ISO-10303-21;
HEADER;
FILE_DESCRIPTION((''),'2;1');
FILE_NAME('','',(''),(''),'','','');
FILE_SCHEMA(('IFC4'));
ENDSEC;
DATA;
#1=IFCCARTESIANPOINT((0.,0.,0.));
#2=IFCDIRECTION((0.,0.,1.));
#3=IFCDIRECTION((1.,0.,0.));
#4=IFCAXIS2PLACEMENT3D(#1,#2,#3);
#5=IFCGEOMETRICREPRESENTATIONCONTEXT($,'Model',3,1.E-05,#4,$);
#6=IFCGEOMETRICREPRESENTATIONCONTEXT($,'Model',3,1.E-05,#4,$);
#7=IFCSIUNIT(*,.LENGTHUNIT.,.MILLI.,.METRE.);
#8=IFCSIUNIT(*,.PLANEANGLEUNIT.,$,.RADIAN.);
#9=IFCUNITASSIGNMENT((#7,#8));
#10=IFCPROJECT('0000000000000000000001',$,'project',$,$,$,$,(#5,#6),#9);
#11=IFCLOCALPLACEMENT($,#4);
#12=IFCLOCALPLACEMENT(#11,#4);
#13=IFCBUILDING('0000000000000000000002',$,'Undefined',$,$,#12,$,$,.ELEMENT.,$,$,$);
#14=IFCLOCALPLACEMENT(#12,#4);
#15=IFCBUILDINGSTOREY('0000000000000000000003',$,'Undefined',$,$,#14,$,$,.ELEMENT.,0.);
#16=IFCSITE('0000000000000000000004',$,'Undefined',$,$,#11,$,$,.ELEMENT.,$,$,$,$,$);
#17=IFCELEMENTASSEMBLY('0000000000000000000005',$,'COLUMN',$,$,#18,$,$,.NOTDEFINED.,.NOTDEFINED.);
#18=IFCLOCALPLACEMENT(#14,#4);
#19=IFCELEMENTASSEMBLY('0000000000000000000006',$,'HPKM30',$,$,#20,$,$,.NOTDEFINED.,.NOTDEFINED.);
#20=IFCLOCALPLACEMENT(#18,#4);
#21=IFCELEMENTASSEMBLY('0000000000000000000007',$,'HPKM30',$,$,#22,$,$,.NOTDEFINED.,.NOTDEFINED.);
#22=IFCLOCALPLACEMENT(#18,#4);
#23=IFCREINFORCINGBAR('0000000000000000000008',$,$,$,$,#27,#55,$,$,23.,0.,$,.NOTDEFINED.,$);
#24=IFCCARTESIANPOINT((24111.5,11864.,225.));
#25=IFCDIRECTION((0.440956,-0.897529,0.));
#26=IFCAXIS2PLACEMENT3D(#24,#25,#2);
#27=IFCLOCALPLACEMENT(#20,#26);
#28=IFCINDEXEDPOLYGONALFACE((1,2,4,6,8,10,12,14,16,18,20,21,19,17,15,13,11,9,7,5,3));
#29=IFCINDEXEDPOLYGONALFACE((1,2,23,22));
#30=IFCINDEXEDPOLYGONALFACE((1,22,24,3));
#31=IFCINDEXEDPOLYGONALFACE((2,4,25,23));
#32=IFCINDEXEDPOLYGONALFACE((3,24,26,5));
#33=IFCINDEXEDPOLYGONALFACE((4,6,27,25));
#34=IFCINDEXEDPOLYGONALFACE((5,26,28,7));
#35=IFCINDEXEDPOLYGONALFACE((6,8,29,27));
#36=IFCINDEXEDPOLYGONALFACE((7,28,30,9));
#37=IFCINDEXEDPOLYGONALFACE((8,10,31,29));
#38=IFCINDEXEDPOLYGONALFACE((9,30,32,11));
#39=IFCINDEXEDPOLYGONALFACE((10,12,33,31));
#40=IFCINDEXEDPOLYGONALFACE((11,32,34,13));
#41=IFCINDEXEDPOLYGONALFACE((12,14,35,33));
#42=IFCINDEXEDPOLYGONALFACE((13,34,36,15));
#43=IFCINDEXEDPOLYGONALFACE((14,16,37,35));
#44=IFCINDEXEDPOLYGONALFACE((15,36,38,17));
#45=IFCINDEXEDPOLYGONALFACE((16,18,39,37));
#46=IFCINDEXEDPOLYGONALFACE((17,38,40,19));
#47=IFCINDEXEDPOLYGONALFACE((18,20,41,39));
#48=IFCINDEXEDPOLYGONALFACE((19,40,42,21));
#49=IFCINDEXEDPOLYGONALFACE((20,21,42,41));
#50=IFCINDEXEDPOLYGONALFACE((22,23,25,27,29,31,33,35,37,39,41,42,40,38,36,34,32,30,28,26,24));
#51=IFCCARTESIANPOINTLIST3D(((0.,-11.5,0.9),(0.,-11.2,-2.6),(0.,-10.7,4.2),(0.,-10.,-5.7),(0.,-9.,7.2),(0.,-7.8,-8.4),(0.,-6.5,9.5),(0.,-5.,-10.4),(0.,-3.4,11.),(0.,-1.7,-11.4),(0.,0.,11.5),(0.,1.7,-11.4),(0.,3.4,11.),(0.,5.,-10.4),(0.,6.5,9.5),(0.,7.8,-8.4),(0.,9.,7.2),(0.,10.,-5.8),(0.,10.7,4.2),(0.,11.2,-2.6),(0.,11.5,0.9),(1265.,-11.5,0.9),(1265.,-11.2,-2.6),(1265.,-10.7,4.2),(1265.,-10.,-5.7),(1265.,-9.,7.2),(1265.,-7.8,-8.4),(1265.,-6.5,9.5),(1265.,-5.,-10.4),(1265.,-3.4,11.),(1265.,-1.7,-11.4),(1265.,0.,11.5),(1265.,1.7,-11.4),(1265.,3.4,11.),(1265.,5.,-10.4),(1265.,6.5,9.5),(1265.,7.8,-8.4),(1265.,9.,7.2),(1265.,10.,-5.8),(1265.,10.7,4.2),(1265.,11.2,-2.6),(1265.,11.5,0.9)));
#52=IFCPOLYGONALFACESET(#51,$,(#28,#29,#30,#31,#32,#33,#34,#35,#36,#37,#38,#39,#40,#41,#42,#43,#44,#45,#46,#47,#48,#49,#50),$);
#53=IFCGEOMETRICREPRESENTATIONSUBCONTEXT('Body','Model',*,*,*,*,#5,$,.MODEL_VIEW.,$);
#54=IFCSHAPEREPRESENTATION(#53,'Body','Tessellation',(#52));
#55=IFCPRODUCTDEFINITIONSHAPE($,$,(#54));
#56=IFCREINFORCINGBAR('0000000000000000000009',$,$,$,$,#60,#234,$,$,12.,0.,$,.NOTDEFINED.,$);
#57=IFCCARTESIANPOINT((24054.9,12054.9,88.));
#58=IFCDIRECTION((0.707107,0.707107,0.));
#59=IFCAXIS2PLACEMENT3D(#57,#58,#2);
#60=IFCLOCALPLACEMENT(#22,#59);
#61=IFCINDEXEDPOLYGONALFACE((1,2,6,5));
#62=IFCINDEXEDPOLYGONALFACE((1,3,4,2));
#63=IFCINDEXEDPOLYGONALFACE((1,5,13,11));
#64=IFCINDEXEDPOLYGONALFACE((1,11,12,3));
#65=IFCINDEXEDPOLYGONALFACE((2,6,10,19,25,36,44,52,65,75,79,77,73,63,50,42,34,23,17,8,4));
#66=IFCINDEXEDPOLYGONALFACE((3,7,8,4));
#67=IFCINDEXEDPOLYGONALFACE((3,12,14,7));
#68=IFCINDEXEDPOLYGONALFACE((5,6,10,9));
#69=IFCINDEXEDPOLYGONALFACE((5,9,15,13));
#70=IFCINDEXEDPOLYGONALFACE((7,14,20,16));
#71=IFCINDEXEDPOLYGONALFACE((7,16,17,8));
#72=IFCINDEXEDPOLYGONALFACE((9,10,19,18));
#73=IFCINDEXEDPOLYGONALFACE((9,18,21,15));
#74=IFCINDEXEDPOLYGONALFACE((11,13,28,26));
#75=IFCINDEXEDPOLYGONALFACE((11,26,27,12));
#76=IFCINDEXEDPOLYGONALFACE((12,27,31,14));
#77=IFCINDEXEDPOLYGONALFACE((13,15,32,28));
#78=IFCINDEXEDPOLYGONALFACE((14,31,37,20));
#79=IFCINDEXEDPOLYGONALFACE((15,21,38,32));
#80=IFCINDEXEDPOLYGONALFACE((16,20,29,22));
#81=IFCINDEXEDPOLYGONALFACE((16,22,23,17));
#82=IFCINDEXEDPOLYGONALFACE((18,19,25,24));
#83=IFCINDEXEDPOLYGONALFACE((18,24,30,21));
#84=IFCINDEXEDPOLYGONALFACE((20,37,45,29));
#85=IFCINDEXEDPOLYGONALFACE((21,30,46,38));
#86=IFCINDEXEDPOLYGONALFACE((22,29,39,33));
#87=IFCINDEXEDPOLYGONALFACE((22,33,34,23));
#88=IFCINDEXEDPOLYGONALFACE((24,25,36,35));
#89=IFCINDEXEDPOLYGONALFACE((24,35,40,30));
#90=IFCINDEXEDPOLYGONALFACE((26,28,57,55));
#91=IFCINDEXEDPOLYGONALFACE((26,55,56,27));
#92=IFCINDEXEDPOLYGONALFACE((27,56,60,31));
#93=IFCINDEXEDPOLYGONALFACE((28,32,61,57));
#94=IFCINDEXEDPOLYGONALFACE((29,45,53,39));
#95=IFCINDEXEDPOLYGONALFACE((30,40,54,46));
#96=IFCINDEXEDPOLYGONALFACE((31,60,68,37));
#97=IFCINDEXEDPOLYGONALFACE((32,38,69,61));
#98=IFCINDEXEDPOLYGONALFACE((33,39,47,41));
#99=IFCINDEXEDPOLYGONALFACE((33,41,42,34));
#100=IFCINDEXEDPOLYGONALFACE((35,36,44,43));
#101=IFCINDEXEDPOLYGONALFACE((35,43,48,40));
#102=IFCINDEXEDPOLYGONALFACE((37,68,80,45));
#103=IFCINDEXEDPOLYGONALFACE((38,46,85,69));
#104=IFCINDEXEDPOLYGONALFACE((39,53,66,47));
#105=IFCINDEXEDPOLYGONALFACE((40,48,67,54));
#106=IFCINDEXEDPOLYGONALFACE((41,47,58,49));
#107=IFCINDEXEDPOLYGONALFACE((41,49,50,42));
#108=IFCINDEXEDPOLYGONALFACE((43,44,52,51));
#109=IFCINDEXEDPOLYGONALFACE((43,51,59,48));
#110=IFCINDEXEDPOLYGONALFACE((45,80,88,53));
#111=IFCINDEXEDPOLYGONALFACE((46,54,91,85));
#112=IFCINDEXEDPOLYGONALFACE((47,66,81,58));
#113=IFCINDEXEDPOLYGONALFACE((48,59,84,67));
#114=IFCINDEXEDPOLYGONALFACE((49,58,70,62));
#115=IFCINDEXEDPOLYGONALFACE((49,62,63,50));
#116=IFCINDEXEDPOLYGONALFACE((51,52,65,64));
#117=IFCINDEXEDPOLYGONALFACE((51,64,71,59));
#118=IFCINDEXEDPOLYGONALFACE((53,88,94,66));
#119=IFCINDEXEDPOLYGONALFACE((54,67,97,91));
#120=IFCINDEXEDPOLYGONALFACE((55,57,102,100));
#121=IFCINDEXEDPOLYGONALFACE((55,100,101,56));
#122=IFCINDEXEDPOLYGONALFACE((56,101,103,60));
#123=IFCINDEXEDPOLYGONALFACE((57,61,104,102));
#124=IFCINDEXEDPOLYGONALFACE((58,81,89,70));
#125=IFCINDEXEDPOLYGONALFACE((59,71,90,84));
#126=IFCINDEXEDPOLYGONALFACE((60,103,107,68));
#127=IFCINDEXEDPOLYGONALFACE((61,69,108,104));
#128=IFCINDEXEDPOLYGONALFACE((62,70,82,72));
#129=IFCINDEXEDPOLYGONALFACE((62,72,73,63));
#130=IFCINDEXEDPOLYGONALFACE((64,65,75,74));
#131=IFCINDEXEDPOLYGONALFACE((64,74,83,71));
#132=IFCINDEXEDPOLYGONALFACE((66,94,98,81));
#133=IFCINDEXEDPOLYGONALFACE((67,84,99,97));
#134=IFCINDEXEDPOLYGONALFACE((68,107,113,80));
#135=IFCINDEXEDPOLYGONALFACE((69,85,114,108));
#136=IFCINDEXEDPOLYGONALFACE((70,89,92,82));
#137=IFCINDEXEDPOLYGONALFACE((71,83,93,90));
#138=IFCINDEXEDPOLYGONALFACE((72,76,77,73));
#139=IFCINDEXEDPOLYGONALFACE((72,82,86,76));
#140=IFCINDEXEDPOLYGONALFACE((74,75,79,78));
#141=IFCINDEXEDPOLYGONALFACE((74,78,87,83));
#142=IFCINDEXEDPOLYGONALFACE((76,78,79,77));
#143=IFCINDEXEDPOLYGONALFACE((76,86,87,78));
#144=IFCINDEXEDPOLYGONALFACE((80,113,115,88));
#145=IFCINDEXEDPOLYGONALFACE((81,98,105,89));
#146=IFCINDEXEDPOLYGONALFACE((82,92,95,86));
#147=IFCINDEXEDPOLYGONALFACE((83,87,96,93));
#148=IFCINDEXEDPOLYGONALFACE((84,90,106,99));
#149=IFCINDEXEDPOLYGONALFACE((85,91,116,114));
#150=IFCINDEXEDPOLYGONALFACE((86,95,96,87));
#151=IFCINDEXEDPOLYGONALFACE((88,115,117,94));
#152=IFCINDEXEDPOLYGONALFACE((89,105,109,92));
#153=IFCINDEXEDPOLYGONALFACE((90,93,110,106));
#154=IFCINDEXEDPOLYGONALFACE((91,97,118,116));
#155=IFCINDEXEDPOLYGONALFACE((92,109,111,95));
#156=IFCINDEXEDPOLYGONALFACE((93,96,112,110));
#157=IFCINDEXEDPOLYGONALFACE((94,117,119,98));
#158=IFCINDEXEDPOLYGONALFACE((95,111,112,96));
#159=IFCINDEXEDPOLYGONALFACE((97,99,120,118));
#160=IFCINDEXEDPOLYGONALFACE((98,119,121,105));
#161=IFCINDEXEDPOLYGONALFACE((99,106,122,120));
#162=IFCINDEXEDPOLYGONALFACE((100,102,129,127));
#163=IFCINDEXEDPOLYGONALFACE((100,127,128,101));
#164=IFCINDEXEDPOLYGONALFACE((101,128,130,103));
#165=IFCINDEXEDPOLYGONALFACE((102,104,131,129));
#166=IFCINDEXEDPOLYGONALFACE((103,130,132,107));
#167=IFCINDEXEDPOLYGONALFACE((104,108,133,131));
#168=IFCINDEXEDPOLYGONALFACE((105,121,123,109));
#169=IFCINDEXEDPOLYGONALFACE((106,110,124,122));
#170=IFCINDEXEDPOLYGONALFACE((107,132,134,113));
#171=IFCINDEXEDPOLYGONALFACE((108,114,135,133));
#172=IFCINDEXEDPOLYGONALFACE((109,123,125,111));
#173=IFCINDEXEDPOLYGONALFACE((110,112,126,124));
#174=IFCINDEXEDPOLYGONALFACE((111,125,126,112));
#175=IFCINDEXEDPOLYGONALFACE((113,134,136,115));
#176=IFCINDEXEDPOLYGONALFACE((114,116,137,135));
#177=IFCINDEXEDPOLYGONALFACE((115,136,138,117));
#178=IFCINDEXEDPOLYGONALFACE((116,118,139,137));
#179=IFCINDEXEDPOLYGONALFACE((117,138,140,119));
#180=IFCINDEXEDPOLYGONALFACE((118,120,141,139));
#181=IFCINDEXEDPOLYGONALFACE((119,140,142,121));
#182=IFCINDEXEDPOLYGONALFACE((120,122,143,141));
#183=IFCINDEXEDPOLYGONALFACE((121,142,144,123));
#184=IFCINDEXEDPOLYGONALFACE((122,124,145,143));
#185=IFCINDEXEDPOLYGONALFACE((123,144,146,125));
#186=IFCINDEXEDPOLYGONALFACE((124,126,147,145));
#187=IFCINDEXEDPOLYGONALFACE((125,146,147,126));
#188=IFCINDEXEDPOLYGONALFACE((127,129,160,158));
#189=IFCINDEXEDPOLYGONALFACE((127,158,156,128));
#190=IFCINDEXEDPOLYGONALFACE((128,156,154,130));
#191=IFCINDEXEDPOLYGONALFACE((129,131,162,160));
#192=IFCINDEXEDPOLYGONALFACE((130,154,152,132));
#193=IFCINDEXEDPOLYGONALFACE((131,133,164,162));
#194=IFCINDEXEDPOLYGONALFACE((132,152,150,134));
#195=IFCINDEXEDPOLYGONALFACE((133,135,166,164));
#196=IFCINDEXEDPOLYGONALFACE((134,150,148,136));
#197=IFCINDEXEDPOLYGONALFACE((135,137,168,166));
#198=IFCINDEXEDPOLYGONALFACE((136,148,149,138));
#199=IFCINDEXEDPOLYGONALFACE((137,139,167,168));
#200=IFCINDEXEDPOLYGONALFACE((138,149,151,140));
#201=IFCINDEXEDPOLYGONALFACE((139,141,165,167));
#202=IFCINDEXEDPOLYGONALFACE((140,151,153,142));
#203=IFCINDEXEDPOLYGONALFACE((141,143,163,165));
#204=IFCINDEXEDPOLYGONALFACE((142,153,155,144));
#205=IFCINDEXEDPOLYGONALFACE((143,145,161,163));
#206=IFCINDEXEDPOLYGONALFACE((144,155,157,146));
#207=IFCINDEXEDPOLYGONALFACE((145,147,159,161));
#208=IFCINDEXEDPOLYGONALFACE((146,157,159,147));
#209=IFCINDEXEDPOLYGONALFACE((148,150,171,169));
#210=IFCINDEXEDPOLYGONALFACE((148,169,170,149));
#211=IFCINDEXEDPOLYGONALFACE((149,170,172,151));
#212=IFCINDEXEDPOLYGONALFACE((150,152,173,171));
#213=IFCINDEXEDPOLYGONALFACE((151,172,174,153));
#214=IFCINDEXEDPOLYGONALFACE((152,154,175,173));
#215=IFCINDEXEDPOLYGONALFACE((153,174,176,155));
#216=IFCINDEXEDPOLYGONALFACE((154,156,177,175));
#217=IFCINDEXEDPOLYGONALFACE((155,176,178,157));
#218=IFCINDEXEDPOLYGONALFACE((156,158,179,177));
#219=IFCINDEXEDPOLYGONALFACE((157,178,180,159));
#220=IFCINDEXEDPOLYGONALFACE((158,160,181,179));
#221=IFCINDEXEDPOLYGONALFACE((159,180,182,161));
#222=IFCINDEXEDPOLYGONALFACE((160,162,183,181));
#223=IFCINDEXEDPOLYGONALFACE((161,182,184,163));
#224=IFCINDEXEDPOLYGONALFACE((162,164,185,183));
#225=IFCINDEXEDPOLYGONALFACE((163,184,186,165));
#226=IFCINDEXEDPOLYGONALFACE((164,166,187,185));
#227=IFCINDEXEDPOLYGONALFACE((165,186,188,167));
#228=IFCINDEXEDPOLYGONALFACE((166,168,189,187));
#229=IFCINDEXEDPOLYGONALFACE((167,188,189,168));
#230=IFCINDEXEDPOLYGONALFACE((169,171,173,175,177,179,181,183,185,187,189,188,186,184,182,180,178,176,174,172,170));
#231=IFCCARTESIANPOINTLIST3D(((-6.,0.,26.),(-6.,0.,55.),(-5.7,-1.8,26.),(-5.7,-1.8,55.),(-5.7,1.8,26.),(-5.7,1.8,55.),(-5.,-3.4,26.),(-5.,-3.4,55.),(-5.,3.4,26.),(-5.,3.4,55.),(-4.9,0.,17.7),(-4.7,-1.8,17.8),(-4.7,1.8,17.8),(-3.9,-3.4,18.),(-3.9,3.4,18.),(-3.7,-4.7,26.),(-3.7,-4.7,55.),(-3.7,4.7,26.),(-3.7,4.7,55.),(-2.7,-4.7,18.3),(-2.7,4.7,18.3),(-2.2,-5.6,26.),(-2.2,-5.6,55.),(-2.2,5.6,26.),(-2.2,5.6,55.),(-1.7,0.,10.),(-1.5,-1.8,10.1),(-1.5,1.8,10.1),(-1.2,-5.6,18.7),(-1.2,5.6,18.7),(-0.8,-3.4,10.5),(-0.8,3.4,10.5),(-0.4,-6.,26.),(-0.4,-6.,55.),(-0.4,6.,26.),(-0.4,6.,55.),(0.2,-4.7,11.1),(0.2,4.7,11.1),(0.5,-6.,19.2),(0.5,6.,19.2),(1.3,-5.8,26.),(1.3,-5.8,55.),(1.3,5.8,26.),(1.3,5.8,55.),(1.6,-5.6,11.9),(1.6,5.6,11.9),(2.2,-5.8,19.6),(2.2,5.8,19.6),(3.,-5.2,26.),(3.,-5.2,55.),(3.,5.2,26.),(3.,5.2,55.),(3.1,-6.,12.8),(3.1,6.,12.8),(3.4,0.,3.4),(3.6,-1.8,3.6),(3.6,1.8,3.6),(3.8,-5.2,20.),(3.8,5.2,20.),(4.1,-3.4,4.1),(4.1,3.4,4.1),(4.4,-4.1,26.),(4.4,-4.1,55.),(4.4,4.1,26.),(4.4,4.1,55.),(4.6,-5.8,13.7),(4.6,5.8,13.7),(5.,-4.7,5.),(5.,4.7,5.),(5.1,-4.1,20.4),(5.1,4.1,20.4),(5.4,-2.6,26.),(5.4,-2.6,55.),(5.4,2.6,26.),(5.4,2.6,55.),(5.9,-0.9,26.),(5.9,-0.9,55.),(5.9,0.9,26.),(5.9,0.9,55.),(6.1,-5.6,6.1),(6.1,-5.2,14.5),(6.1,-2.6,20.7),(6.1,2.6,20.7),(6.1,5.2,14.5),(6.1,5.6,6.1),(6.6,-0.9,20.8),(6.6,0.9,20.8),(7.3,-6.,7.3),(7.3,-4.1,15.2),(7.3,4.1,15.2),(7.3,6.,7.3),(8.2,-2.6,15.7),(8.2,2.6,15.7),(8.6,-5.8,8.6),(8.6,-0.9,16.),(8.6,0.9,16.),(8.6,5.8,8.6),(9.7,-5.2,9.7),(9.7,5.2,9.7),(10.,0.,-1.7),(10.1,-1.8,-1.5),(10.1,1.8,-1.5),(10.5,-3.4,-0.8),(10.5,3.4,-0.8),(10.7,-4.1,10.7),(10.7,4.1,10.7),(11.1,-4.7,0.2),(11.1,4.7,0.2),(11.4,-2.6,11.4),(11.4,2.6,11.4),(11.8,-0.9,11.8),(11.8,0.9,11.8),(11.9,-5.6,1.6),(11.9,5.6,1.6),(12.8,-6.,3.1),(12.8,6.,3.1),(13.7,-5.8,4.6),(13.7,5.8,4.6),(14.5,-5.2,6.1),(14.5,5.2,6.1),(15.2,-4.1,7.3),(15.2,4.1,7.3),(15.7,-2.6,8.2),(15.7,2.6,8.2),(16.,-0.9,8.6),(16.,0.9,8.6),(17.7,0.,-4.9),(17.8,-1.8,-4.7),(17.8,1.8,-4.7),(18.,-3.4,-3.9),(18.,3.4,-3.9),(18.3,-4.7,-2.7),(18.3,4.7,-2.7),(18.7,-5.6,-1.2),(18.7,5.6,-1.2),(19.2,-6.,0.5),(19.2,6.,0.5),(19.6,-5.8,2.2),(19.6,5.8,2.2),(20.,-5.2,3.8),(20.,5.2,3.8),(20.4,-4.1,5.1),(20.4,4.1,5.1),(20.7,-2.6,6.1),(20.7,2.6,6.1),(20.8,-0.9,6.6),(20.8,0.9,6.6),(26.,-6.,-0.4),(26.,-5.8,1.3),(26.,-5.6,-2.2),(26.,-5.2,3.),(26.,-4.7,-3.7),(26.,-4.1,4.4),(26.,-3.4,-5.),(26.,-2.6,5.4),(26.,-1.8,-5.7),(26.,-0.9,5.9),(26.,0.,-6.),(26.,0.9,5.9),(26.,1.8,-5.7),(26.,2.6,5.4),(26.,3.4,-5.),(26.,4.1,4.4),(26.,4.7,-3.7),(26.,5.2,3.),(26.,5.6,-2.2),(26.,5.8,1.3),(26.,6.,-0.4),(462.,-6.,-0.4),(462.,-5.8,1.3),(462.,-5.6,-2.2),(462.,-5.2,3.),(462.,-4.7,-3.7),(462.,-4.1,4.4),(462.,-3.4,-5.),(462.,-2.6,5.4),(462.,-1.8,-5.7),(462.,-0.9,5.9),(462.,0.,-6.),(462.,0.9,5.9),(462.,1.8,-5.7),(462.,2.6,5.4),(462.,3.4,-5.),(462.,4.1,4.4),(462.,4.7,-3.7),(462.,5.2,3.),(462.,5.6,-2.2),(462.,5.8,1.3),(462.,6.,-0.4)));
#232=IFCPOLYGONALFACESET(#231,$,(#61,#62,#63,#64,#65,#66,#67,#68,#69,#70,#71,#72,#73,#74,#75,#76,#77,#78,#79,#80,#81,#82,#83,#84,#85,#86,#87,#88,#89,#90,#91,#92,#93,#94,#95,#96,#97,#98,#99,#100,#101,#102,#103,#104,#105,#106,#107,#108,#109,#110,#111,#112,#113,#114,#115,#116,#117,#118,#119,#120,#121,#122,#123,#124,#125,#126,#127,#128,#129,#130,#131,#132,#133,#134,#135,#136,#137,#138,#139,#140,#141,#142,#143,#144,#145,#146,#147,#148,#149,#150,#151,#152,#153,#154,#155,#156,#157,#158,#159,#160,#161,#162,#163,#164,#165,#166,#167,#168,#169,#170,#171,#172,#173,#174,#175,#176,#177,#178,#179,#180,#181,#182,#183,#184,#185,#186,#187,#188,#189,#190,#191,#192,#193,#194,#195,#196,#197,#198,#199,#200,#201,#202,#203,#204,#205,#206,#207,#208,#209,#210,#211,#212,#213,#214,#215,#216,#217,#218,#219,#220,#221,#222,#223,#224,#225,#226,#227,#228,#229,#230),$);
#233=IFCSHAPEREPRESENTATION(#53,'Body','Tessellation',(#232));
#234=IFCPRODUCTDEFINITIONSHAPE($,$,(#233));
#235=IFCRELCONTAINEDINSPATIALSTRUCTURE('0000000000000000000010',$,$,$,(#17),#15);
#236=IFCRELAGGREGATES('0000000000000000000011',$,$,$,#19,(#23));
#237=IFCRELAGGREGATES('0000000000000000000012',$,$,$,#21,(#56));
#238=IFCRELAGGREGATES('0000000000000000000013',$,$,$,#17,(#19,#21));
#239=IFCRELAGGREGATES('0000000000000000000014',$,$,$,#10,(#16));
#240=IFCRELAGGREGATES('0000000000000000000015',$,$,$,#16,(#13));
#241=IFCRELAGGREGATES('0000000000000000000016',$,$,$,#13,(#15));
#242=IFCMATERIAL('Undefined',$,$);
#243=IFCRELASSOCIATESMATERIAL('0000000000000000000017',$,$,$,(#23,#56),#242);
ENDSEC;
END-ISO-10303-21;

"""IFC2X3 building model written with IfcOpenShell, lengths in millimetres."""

from ifc_helpers import new_model, entity, si_unit, frame, origin_with_axes, place, context, subcontext, project, spatial, source, transform, mapped, material, element, aggregate, save


model = new_model("IFC2X3")

# Units and contexts
model_context_1 = context("Model", 3, precision=1e-05, world=origin_with_axes())
model_context_2 = context("Model", 3, precision=1e-05, world=origin_with_axes())
body_context = subcontext(model_context_1, "Body", "Model", "MODEL_VIEW")
ifc_project = project(units=[si_unit("LENGTHUNIT", "METRE", prefix="MILLI"), si_unit("PLANEANGLEUNIT", "RADIAN")], contexts=[model_context_1, model_context_2])

# Site, building, storey
site_placement = place(None, origin_with_axes())
site = spatial("IfcSite", under=ifc_project, at=site_placement, Name="Undefined", CompositionType="ELEMENT")
building_placement = place(site_placement, origin_with_axes())
building = spatial("IfcBuilding", under=site, at=building_placement, Name="Undefined", CompositionType="ELEMENT")
storey_placement = place(building_placement, origin_with_axes())
storey = spatial("IfcBuildingStorey", under=building, at=storey_placement, Name="Undefined", CompositionType="ELEMENT", Elevation=0.0)

# Element assembly
assembly_1_placement = place(storey_placement, origin_with_axes())
assembly_1 = element("IfcElementAssembly", 1, at=assembly_1_placement, inside=storey, Name="COLUMN", AssemblyPlace="NOTDEFINED", PredefinedType="NOTDEFINED")

# Element assemblies
assembly_2_placement = place(assembly_1_placement, origin_with_axes())
assembly_2 = element("IfcElementAssembly", 2, at=assembly_2_placement, Name="HPKM30", AssemblyPlace="NOTDEFINED", PredefinedType="NOTDEFINED")
assembly_3_placement = place(assembly_1_placement, origin_with_axes())
assembly_3 = element("IfcElementAssembly", 3, at=assembly_3_placement, Name="HPKM30", AssemblyPlace="NOTDEFINED", PredefinedType="NOTDEFINED")

# Shared definitions
ifc_material_1 = material(Name="Undefined")

# Reinforcing bars
shared_shape_1 = source(origin_with_axes(), body_context, "Body", "AdvancedSweptSolid", [
    entity("IfcSweptDiskSolid", entity("IfcTrimmedCurve", entity("IfcLine", entity("IfcCartesianPoint", [0.0, 0.0, 0.0]), entity("IfcVector", entity("IfcDirection", [1.0, 0.0, 0.0]), 1.0)), [entity("IfcParameterValue", 0.0)], [entity("IfcParameterValue", 1265.0)], True, "PARAMETER"), 11.5, None, 0.0, 1265.0),
])
reinforcing_bar_1_placement = place(assembly_2_placement, frame((24111.5, 11864.0, 225.0), z_axis=(0.440956, -0.897529, 0.0), x_axis=(0.0, 0.0, 1.0)))
reinforcing_bar_1 = element("IfcReinforcingBar", 4, at=reinforcing_bar_1_placement, material=ifc_material_1, BarRole="NOTDEFINED", CrossSectionArea=0.0, NominalDiameter=23.0, context=body_context, shape_type="MappedRepresentation", body=[
    mapped(shared_shape_1, transform((0.0, 0.0, 0.0))),
])
aggregate(assembly_2, [reinforcing_bar_1])
shared_shape_2 = source(origin_with_axes(), body_context, "Body", "AdvancedSweptSolid", [
    entity("IfcSweptDiskSolid", entity("IfcCompositeCurve", [entity("IfcCompositeCurveSegment", "CONTINUOUS", True, entity("IfcTrimmedCurve", entity("IfcLine", entity("IfcCartesianPoint", [0.0, 0.0, 0.0]), entity("IfcVector", entity("IfcDirection", [0.0, 0.0, -1.0]), 1.0)), [entity("IfcParameterValue", 0.0)], [entity("IfcParameterValue", 29.0)], True, "PARAMETER")), entity("IfcCompositeCurveSegment", "CONTINUOUS", True, entity("IfcTrimmedCurve", entity("IfcCircle", entity("IfcAxis2Placement3D", entity("IfcCartesianPoint", [26.0, 0.0, -29.0]), entity("IfcDirection", [0.0, -1.0, 0.0]), entity("IfcDirection", [-1.0, 0.0, 0.0])), 26.0), [entity("IfcParameterValue", 0.0)], [entity("IfcParameterValue", 1.570796)], True, "PARAMETER")), entity("IfcCompositeCurveSegment", "DISCONTINUOUS", True, entity("IfcTrimmedCurve", entity("IfcLine", entity("IfcCartesianPoint", [26.0, 0.0, -55.0]), entity("IfcVector", entity("IfcDirection", [1.0, 0.0, 0.0]), 1.0)), [entity("IfcParameterValue", 0.0)], [entity("IfcParameterValue", 436.0)], True, "PARAMETER"))], False), 6.0, None, 0.0, 466.6),
])
reinforcing_bar_2_placement = place(assembly_3_placement, frame((24054.9, 12054.9, 88.0), z_axis=(0.707107, 0.707107, 0.0), x_axis=(0.0, 0.0, 1.0)))
reinforcing_bar_2 = element("IfcReinforcingBar", 5, at=reinforcing_bar_2_placement, material=ifc_material_1, BarRole="NOTDEFINED", CrossSectionArea=0.0, NominalDiameter=12.0, context=body_context, shape_type="MappedRepresentation", body=[
    mapped(shared_shape_2, transform((0.0, 0.0, 55.0))),
])
aggregate(assembly_3, [reinforcing_bar_2])
aggregate(assembly_1, [assembly_2, assembly_3])

save(model, "model.ifc")
